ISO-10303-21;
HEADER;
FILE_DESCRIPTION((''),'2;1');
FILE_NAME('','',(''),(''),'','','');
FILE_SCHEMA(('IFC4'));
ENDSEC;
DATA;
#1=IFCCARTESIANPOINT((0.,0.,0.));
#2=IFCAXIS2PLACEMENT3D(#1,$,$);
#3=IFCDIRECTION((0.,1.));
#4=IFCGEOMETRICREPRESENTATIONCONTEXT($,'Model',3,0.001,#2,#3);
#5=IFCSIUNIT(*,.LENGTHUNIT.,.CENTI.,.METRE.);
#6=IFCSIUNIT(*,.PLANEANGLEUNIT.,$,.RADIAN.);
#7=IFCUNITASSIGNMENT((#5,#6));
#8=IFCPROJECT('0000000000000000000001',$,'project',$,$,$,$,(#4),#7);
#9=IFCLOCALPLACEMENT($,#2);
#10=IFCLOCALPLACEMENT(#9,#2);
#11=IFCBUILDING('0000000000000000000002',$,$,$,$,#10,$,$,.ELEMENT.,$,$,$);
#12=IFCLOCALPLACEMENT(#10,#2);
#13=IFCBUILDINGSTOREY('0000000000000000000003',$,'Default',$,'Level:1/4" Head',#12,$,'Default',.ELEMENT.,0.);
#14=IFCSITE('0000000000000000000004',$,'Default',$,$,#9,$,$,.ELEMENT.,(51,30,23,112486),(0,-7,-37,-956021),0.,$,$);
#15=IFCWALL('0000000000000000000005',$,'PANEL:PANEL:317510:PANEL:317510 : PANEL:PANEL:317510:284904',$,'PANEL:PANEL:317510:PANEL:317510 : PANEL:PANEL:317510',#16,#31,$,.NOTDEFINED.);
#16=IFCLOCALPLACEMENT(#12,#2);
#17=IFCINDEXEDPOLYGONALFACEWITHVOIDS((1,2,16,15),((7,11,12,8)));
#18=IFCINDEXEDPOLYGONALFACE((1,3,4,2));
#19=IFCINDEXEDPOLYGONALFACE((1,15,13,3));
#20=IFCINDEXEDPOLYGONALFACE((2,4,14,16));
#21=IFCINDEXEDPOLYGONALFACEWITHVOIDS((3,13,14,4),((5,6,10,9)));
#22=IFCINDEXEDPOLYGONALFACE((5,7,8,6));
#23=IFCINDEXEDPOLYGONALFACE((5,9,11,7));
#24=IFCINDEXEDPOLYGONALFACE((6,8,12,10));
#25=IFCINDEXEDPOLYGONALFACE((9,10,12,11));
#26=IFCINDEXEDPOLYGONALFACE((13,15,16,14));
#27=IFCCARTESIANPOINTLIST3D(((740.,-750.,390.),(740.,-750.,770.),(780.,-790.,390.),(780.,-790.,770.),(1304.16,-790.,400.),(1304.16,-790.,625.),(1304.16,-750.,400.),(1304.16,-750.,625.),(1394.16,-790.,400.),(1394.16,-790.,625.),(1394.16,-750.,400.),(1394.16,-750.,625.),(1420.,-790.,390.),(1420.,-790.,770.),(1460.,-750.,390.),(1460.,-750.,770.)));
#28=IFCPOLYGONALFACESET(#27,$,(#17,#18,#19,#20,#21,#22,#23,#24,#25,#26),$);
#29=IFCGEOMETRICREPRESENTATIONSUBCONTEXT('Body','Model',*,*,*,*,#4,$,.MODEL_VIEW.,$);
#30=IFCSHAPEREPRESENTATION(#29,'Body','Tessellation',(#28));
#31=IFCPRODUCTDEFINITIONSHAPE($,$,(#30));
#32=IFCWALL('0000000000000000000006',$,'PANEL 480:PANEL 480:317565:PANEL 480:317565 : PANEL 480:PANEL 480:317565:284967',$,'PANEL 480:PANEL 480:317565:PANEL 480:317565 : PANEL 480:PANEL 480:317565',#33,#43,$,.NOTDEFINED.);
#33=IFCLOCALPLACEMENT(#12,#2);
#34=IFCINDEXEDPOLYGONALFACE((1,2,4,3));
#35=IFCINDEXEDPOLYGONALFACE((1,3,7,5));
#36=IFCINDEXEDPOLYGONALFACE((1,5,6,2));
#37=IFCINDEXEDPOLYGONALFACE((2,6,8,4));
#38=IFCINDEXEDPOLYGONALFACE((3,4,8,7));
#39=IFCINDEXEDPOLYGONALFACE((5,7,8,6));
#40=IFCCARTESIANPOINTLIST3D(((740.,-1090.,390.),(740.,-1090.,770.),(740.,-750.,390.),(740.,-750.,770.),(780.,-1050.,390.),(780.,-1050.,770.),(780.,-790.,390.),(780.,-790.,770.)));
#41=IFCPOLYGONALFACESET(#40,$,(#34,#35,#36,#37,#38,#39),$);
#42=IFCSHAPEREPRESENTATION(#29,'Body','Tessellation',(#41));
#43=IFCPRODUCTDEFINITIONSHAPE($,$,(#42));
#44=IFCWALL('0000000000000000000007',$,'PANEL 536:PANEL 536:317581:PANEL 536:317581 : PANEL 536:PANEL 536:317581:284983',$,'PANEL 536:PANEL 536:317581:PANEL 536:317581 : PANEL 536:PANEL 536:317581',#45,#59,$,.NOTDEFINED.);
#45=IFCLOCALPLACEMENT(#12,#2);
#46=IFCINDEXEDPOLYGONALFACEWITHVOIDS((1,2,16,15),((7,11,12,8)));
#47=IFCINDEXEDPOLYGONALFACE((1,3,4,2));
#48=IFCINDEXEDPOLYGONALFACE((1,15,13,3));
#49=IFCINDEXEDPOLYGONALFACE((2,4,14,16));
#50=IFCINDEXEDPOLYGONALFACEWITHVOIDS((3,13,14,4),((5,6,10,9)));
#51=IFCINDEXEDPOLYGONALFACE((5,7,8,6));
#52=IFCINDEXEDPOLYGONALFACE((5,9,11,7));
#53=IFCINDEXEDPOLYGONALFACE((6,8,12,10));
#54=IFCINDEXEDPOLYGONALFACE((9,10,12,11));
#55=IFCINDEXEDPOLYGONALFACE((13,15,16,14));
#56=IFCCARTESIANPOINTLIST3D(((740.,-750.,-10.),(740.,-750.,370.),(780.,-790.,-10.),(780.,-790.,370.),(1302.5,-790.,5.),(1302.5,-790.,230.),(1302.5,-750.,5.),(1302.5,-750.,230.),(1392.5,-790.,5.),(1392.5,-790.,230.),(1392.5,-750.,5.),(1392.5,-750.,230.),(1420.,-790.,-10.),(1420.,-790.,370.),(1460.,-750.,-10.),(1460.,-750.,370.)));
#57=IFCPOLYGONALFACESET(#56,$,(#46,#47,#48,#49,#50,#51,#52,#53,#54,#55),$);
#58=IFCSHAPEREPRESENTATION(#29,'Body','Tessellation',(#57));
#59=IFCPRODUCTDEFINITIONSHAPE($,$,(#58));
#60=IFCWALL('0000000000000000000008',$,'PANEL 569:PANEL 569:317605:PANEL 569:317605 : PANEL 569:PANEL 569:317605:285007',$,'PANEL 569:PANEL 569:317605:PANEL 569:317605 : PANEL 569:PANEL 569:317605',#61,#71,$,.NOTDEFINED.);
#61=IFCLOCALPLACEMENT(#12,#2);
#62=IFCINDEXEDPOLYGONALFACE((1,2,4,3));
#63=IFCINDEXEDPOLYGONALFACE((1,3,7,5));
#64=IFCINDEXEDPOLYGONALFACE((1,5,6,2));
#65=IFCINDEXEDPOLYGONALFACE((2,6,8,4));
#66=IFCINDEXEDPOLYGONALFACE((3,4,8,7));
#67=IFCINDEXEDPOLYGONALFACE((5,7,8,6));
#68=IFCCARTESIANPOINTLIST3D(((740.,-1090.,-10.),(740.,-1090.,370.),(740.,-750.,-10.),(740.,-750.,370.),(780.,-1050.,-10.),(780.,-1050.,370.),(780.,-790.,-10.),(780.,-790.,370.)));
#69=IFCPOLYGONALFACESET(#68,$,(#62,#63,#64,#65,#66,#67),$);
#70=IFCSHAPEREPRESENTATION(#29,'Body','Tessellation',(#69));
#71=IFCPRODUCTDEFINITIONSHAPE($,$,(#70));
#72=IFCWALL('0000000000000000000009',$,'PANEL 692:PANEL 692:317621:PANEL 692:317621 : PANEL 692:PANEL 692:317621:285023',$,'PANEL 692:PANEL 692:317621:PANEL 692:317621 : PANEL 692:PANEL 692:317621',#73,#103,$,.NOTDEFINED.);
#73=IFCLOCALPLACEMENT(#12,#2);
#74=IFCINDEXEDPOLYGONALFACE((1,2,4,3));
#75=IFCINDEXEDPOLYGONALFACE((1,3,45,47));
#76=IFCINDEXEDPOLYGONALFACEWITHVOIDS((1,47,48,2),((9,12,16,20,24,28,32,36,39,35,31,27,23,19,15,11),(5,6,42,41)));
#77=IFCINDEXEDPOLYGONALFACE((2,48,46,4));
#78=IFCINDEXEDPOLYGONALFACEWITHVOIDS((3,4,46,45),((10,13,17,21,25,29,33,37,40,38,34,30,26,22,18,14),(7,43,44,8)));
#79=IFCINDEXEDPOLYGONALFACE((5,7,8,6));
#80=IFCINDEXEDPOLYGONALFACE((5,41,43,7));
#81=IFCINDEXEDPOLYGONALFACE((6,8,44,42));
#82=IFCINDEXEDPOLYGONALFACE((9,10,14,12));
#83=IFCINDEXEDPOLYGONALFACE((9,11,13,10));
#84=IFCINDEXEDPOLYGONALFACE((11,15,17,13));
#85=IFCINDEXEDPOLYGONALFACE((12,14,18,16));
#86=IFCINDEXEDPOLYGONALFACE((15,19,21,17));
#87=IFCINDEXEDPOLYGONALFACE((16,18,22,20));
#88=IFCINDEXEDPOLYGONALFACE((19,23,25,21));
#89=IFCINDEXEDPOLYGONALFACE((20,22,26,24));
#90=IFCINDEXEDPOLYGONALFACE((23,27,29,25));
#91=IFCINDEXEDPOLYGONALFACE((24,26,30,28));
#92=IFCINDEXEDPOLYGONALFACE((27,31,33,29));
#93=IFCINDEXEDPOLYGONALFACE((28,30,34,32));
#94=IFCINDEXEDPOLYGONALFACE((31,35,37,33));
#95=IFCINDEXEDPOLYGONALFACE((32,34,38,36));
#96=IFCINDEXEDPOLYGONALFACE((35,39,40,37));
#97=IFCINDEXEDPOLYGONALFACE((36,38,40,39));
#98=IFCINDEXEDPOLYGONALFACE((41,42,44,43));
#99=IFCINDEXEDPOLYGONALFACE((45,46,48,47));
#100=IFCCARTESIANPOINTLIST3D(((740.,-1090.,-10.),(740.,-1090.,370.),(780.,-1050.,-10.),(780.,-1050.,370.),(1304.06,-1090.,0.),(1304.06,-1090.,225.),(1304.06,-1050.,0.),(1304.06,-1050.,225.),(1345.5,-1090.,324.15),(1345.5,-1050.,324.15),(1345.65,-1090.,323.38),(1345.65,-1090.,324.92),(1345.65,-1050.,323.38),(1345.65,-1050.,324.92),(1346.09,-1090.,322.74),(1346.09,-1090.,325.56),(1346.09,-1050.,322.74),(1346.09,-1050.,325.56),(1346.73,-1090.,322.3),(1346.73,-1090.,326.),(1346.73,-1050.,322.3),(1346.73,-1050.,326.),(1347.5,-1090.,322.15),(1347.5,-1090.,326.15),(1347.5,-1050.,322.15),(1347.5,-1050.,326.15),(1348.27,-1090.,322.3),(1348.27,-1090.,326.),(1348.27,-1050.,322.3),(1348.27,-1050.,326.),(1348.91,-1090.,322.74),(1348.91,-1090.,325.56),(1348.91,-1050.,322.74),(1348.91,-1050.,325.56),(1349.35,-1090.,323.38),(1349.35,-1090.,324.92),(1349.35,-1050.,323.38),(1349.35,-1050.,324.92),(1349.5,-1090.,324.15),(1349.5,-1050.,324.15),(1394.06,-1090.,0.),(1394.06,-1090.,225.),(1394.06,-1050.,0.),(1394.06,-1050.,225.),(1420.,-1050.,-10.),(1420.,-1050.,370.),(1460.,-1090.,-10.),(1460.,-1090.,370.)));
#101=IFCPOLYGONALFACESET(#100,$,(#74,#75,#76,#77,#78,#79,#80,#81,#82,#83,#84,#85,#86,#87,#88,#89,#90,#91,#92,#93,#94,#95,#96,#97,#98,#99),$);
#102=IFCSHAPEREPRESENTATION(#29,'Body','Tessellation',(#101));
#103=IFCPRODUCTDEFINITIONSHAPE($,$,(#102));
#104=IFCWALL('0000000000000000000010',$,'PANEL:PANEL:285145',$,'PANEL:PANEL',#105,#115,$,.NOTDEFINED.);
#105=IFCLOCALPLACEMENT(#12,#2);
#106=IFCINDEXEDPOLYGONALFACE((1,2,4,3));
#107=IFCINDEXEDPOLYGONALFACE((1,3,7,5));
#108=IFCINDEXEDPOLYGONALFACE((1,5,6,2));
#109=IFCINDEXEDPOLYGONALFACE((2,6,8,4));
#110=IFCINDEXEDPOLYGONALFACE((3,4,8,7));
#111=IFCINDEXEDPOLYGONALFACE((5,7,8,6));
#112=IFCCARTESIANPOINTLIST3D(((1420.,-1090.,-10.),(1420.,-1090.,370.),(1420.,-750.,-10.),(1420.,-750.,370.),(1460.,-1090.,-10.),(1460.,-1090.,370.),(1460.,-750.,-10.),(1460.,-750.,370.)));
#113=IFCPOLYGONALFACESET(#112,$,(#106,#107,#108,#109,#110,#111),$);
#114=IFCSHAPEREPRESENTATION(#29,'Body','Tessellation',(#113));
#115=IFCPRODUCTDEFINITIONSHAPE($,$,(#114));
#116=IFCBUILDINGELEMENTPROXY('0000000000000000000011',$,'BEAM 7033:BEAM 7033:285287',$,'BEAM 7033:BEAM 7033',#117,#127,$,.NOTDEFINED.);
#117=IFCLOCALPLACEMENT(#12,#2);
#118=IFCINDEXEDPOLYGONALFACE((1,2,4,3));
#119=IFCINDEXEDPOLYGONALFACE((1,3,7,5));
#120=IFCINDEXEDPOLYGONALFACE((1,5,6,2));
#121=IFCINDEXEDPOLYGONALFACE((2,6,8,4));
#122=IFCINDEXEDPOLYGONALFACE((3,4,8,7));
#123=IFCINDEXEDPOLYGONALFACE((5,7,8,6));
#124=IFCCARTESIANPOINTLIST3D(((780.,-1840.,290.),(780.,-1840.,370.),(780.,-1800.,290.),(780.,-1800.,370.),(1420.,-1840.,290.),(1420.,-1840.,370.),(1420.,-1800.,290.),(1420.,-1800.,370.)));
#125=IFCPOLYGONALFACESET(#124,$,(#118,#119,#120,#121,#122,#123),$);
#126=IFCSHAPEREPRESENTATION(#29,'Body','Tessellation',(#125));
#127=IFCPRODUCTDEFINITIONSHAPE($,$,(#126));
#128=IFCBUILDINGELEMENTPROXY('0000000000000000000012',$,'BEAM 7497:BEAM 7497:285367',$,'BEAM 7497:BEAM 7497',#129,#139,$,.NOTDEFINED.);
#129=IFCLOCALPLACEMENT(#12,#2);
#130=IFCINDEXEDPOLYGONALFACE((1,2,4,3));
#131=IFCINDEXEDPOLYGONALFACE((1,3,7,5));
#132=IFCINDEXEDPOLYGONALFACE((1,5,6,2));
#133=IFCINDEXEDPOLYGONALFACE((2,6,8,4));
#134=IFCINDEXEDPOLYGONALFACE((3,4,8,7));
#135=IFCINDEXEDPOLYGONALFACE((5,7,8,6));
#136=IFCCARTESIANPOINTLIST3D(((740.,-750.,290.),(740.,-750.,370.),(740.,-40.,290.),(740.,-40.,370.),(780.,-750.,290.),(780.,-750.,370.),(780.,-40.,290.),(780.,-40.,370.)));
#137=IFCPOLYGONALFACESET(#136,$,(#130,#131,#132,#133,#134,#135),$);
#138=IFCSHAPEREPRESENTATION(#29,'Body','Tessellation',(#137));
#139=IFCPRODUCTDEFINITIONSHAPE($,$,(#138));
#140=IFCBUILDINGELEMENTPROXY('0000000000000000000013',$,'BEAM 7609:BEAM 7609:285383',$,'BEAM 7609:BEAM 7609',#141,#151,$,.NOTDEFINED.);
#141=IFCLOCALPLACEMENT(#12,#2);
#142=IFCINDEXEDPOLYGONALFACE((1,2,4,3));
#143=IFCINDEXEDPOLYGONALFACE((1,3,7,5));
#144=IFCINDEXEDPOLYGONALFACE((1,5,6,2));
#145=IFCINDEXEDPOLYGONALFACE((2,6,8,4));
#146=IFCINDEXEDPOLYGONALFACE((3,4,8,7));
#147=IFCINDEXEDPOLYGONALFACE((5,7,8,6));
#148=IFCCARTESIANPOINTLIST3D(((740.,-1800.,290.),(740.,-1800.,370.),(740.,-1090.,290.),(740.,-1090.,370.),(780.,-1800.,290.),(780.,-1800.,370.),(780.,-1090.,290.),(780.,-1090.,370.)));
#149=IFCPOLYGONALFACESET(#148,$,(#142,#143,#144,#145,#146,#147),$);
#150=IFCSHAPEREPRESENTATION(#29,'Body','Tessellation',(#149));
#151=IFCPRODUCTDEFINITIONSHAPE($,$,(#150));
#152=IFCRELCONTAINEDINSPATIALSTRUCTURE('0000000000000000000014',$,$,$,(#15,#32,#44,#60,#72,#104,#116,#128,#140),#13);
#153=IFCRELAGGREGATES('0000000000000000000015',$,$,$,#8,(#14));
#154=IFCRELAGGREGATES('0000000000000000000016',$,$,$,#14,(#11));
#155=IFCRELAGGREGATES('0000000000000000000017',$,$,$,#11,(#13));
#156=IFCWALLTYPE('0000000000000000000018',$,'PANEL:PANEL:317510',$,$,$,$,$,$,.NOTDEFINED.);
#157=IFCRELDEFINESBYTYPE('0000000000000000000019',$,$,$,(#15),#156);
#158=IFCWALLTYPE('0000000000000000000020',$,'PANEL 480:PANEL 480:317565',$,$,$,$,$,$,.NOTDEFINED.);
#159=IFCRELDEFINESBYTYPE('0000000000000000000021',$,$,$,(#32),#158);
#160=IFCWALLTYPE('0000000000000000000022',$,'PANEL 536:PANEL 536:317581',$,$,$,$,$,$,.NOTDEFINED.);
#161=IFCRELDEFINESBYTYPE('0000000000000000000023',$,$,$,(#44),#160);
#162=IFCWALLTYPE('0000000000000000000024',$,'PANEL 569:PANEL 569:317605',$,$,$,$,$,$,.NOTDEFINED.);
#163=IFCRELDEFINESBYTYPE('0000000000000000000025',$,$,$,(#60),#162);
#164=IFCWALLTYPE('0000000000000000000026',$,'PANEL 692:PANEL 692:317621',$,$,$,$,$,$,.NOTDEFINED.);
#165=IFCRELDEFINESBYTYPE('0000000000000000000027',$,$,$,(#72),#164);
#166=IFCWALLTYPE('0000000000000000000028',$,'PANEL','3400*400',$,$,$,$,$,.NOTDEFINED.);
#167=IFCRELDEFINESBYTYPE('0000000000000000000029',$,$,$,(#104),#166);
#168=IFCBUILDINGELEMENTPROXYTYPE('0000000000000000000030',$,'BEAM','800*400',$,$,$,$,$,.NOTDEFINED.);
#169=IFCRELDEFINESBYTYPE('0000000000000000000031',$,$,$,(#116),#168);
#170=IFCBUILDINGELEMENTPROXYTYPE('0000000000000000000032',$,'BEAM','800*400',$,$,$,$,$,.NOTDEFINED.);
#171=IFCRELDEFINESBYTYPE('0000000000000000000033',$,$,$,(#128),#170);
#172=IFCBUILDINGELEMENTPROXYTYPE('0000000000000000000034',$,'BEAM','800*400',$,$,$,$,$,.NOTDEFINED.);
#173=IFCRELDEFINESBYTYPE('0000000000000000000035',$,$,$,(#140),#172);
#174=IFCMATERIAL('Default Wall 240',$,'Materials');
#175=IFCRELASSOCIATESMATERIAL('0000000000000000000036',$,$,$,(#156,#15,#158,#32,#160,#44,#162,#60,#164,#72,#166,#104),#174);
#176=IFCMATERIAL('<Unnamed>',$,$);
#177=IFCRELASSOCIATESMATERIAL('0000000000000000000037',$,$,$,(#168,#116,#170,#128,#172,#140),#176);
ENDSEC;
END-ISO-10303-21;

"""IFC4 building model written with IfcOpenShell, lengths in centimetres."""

from ifc_helpers import new_model, si_unit, direction, frame, frame_2d, origin, origin_2d_with_axis, place, context, subcontext, project, spatial, polyline, rectangle, outline, extrude, source, transform, mapped, material, type_object, type_shapes, element, save


model = new_model("IFC4")

# Units and contexts
model_context = context("Model", 3, precision=0.001, world=origin(), true_north=direction((0.0, 1.0)))
body_context = subcontext(model_context, "Body", "Model", "MODEL_VIEW")
ifc_project = project(units=[si_unit("LENGTHUNIT", "METRE", prefix="CENTI"), si_unit("PLANEANGLEUNIT", "RADIAN")], contexts=[model_context])

# Site, building, storey
site_placement = place(None, origin())
site = spatial("IfcSite", under=ifc_project, at=site_placement, Name="Default", CompositionType="ELEMENT", RefLatitude=(51, 30, 23, 112486), RefLongitude=(0, -7, -37, -956021), RefElevation=0.0)
building_placement = place(site_placement, origin())
building = spatial("IfcBuilding", under=site, at=building_placement, CompositionType="ELEMENT")
storey_placement = place(building_placement, origin())
storey = spatial("IfcBuildingStorey", under=building, at=storey_placement, Name="Default", ObjectType="Level:1/4\" Head", LongName="Default", CompositionType="ELEMENT", Elevation=0.0)

# Wall, opening
ifc_material_1 = material(Name="Default Wall 240", Category="Materials")
wall_type_1 = type_object("IfcWallType", Name="PANEL:PANEL:317510", PredefinedType="NOTDEFINED", material=ifc_material_1)
wall_1_placement = place(storey_placement, frame((740.0, -790.0, 390.0)))
wall_1 = element("IfcWall", 1, at=wall_1_placement, inside=storey, type_object=wall_type_1, material=ifc_material_1, Name="PANEL:PANEL:317510:PANEL:317510 : PANEL:PANEL:317510:284904", ObjectType="PANEL:PANEL:317510:PANEL:317510 : PANEL:PANEL:317510", PredefinedType="NOTDEFINED", context=body_context, shape_type="SweptSolid", body=[
    extrude(outline(polyline([(-360.0, -20.0), (360.0, -20.0), (320.0, 20.0), (-320.0, 20.0), (-360.0, -20.0)])), frame((360.0, 20.0, 0.0), z_axis=(0.0, 0.0, 1.0), x_axis=(-1.0, 0.0, 0.0)), (0.0, 0.0, 1.0), 380.0),
])
opening_1_placement = place(storey_placement, frame((740.0, -790.0, 390.0)))
element("IfcOpeningElement", 2, at=opening_1_placement, cuts=wall_1, PredefinedType="OPENING", context=body_context, shape_type="SweptSolid", body=[
    extrude(rectangle(XDim=225.0, YDim=90.0, at=frame_2d((0.0, 0.0), x_axis=(0.0, 1.0))), frame((609.16, 0.0, 122.5), z_axis=(0.0, 1.0, 0.0), x_axis=(-1.0, 0.0, 0.0)), (0.0, 0.0, 1.0), 40.0),
])

# Wall
wall_type_2 = type_object("IfcWallType", Name="PANEL 480:PANEL 480:317565", PredefinedType="NOTDEFINED", material=ifc_material_1)
wall_2_placement = place(storey_placement, frame((740.0, -1090.0, 390.0), z_axis=(0.0, 0.0, 1.0), x_axis=(0.0, 1.0, 0.0)))
element("IfcWall", 3, at=wall_2_placement, inside=storey, type_object=wall_type_2, material=ifc_material_1, Name="PANEL 480:PANEL 480:317565:PANEL 480:317565 : PANEL 480:PANEL 480:317565:284967", ObjectType="PANEL 480:PANEL 480:317565:PANEL 480:317565 : PANEL 480:PANEL 480:317565", PredefinedType="NOTDEFINED", context=body_context, shape_type="SweptSolid", body=[
    extrude(outline(polyline([(-170.0, -20.0), (170.0, -20.0), (130.0, 20.0), (-130.0, 20.0), (-170.0, -20.0)])), frame((170.0, -20.0, 0.0), z_axis=(0.0, 0.0, 1.0), x_axis=(-1.0, 0.0, 0.0)), (0.0, 0.0, 1.0), 380.0),
])

# Wall, opening
wall_type_3 = type_object("IfcWallType", Name="PANEL 536:PANEL 536:317581", PredefinedType="NOTDEFINED", material=ifc_material_1)
wall_3_placement = place(storey_placement, frame((740.0, -790.0, -10.0)))
wall_3 = element("IfcWall", 4, at=wall_3_placement, inside=storey, type_object=wall_type_3, material=ifc_material_1, Name="PANEL 536:PANEL 536:317581:PANEL 536:317581 : PANEL 536:PANEL 536:317581:284983", ObjectType="PANEL 536:PANEL 536:317581:PANEL 536:317581 : PANEL 536:PANEL 536:317581", PredefinedType="NOTDEFINED", context=body_context, shape_type="SweptSolid", body=[
    extrude(outline(polyline([(-360.0, -20.0), (360.0, -20.0), (320.0, 20.0), (-320.0, 20.0), (-360.0, -20.0)])), frame((360.0, 20.0, 0.0), z_axis=(0.0, 0.0, 1.0), x_axis=(-1.0, 0.0, 0.0)), (0.0, 0.0, 1.0), 380.0),
])
opening_2_placement = place(storey_placement, frame((740.0, -790.0, -10.0)))
element("IfcOpeningElement", 5, at=opening_2_placement, cuts=wall_3, PredefinedType="OPENING", context=body_context, shape_type="SweptSolid", body=[
    extrude(rectangle(XDim=225.0, YDim=90.0, at=frame_2d((0.0, 0.0), x_axis=(0.0, 1.0))), frame((607.5, 40.0, 127.5), z_axis=(0.0, -1.0, 0.0), x_axis=(1.0, 0.0, 0.0)), (0.0, 0.0, 1.0), 40.0),
])

# Wall
wall_type_4 = type_object("IfcWallType", Name="PANEL 569:PANEL 569:317605", PredefinedType="NOTDEFINED", material=ifc_material_1)
wall_4_placement = place(storey_placement, frame((740.0, -1090.0, -10.0), z_axis=(0.0, 0.0, 1.0), x_axis=(0.0, 1.0, 0.0)))
element("IfcWall", 6, at=wall_4_placement, inside=storey, type_object=wall_type_4, material=ifc_material_1, Name="PANEL 569:PANEL 569:317605:PANEL 569:317605 : PANEL 569:PANEL 569:317605:285007", ObjectType="PANEL 569:PANEL 569:317605:PANEL 569:317605 : PANEL 569:PANEL 569:317605", PredefinedType="NOTDEFINED", context=body_context, shape_type="SweptSolid", body=[
    extrude(outline(polyline([(-170.0, -20.0), (170.0, -20.0), (130.0, 20.0), (-130.0, 20.0), (-170.0, -20.0)])), frame((170.0, -20.0, 0.0), z_axis=(0.0, 0.0, 1.0), x_axis=(-1.0, 0.0, 0.0)), (0.0, 0.0, 1.0), 380.0),
])

# Wall, openings
wall_type_5 = type_object("IfcWallType", Name="PANEL 692:PANEL 692:317621", PredefinedType="NOTDEFINED", material=ifc_material_1)
wall_5_placement = place(storey_placement, frame((740.0, -1090.0, -10.0)))
wall_5 = element("IfcWall", 7, at=wall_5_placement, inside=storey, type_object=wall_type_5, material=ifc_material_1, Name="PANEL 692:PANEL 692:317621:PANEL 692:317621 : PANEL 692:PANEL 692:317621:285023", ObjectType="PANEL 692:PANEL 692:317621:PANEL 692:317621 : PANEL 692:PANEL 692:317621", PredefinedType="NOTDEFINED", context=body_context, shape_type="SweptSolid", body=[
    extrude(outline(polyline([(-360.0, -20.0), (360.0, -20.0), (320.0, 20.0), (-320.0, 20.0), (-360.0, -20.0)])), frame((360.0, 20.0, 0.0)), (0.0, 0.0, 1.0), 380.0),
])
opening_3_placement = place(storey_placement, frame((740.0, -1090.0, -10.0)))
element("IfcOpeningElement", 8, at=opening_3_placement, cuts=wall_5, PredefinedType="OPENING", context=body_context, shape_type="SweptSolid", body=[
    extrude(outline(polyline([(-0.39, -1.96), (0.39, -1.96), (1.11, -1.66), (1.66, -1.11), (1.96, -0.39), (1.96, 0.39), (1.66, 1.11), (1.11, 1.66), (0.39, 1.96), (-0.39, 1.96), (-1.11, 1.66), (-1.66, 1.11), (-1.96, 0.39), (-1.96, -0.39), (-1.66, -1.11), (-1.11, -1.66), (-0.39, -1.96)])), frame((607.5, 0.0, 334.15), z_axis=(0.0, 1.0, 0.0), x_axis=(-0.980785, 0.0, 0.195091)), (0.0, 0.0, 1.0), 40.0),
])
opening_4_placement = place(storey_placement, frame((740.0, -1090.0, -10.0)))
element("IfcOpeningElement", 9, at=opening_4_placement, cuts=wall_5, PredefinedType="OPENING", context=body_context, shape_type="SweptSolid", body=[
    extrude(rectangle(XDim=225.0, YDim=90.0, at=frame_2d((0.0, 0.0), x_axis=(0.0, 1.0))), frame((609.06, 0.0, 122.5), z_axis=(0.0, 1.0, 0.0), x_axis=(-1.0, 0.0, 0.0)), (0.0, 0.0, 1.0), 40.0),
])

# Wall
wall_type_6 = type_object("IfcWallType", Name="PANEL", Description="3400*400", PredefinedType="NOTDEFINED", material=ifc_material_1)
wall_6_placement = place(storey_placement, frame((1420.0, -1090.0, -10.0), z_axis=(0.0, 0.0, 1.0), x_axis=(0.0, 1.0, 0.0)))
element("IfcWall", 10, at=wall_6_placement, inside=storey, type_object=wall_type_6, material=ifc_material_1, Name="PANEL:PANEL:285145", ObjectType="PANEL:PANEL", PredefinedType="NOTDEFINED", context=body_context, shape_type="SweptSolid", body=[
    extrude(rectangle(XDim=340.0, YDim=40.0, at=frame_2d((0.0, 0.0), x_axis=(1.0, 0.0))), frame((170.0, -20.0, 0.0)), (0.0, 0.0, 1.0), 380.0),
])

# Building element proxies
ifc_material_2 = material(Name="<Unnamed>")
building_element_proxy_type_1 = type_object("IfcBuildingElementProxyType", Name="BEAM", Description="800*400", PredefinedType="NOTDEFINED", material=ifc_material_2)
shared_shape_1 = source(origin(), body_context, "Body", "SweptSolid", [
    extrude(rectangle(XDim=40.0, YDim=640.0, at=origin_2d_with_axis()), frame((320.0, 20.0, 0.0), z_axis=(0.0, 0.0, 1.0), x_axis=(0.0, 1.0, 0.0)), (0.0, 0.0, 1.0), 80.0),
])
type_shapes(building_element_proxy_type_1, [shared_shape_1])
proxy_1_placement = place(storey_placement, frame((780.0, -1840.0, 290.0)))
element("IfcBuildingElementProxy", 11, at=proxy_1_placement, inside=storey, type_object=building_element_proxy_type_1, material=ifc_material_2, Name="BEAM 7033:BEAM 7033:285287", ObjectType="BEAM 7033:BEAM 7033", PredefinedType="NOTDEFINED", context=body_context, shape_type="MappedRepresentation", body=[
    mapped(shared_shape_1, transform((0.0, 0.0, 0.0), scale=1.0)),
])
building_element_proxy_type_2 = type_object("IfcBuildingElementProxyType", Name="BEAM", Description="800*400", PredefinedType="NOTDEFINED", material=ifc_material_2)
shared_shape_2 = source(origin(), body_context, "Body", "SweptSolid", [
    extrude(rectangle(XDim=40.0, YDim=710.0, at=origin_2d_with_axis()), frame((20.0, 355.0, 0.0)), (0.0, 0.0, 1.0), 80.0),
])
type_shapes(building_element_proxy_type_2, [shared_shape_2])
proxy_2_placement = place(storey_placement, frame((740.0, -750.0, 290.0)))
element("IfcBuildingElementProxy", 12, at=proxy_2_placement, inside=storey, type_object=building_element_proxy_type_2, material=ifc_material_2, Name="BEAM 7497:BEAM 7497:285367", ObjectType="BEAM 7497:BEAM 7497", PredefinedType="NOTDEFINED", context=body_context, shape_type="MappedRepresentation", body=[
    mapped(shared_shape_2, transform((0.0, 0.0, 0.0), scale=1.0)),
])
building_element_proxy_type_3 = type_object("IfcBuildingElementProxyType", Name="BEAM", Description="800*400", PredefinedType="NOTDEFINED", material=ifc_material_2)
shared_shape_3 = source(origin(), body_context, "Body", "SweptSolid", [
    extrude(rectangle(XDim=40.0, YDim=710.0, at=origin_2d_with_axis()), frame((20.0, 355.0, 0.0)), (0.0, 0.0, 1.0), 80.0),
])
type_shapes(building_element_proxy_type_3, [shared_shape_3])
proxy_3_placement = place(storey_placement, frame((740.0, -1800.0, 290.0)))
element("IfcBuildingElementProxy", 13, at=proxy_3_placement, inside=storey, type_object=building_element_proxy_type_3, material=ifc_material_2, Name="BEAM 7609:BEAM 7609:285383", ObjectType="BEAM 7609:BEAM 7609", PredefinedType="NOTDEFINED", context=body_context, shape_type="MappedRepresentation", body=[
    mapped(shared_shape_3, transform((0.0, 0.0, 0.0), scale=1.0)),
])

save(model, "model.ifc")
